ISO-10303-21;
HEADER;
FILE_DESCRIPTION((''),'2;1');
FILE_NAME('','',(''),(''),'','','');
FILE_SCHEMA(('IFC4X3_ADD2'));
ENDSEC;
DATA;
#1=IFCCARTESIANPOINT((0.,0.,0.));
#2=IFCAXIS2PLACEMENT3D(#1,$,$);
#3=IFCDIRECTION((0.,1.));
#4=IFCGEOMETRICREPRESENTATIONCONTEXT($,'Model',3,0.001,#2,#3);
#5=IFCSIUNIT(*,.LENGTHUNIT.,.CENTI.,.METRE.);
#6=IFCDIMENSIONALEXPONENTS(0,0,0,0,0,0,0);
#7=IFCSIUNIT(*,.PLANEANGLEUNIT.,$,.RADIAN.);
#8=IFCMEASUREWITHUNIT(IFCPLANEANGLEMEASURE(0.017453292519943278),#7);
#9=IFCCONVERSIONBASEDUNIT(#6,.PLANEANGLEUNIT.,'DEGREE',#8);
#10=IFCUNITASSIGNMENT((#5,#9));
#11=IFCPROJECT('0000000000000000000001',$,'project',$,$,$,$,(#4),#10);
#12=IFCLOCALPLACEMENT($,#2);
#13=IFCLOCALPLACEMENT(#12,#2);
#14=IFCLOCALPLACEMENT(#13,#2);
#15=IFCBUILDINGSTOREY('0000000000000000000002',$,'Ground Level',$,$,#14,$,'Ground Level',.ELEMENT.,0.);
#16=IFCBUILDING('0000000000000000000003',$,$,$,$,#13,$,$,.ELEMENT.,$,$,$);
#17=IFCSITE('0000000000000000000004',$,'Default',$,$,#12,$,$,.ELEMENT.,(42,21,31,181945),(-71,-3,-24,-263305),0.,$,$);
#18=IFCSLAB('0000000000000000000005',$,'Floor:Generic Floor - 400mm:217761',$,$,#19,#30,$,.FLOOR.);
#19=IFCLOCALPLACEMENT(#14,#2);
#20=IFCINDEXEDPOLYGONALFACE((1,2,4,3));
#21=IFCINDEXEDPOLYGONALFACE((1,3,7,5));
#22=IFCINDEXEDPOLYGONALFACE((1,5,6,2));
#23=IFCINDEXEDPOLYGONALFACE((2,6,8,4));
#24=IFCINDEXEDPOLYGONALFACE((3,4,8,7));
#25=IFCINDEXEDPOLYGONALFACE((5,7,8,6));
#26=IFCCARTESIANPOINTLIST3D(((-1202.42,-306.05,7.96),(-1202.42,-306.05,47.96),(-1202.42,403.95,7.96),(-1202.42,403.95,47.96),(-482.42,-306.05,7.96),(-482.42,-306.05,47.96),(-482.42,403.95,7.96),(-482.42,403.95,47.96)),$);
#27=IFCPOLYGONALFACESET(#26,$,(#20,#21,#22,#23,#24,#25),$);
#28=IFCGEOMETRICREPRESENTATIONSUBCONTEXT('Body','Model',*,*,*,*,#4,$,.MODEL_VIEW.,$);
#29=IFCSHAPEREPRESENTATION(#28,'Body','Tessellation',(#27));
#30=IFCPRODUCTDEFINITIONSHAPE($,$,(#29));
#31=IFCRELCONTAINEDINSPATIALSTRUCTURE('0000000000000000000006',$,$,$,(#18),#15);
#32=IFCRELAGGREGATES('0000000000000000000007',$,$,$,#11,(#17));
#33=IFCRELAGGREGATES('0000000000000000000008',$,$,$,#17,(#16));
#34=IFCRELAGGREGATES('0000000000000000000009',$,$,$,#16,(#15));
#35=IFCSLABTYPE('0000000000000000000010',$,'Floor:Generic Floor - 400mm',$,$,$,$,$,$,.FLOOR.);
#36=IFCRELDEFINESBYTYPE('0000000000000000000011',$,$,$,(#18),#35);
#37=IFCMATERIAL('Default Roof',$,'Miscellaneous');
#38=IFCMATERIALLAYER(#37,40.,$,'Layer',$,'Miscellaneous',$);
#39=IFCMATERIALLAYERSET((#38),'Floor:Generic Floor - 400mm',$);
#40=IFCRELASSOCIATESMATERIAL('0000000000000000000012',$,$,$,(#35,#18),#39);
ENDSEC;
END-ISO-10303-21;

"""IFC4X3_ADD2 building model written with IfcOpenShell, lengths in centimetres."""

from ifc_helpers import new_model, entity, si_unit, converted_unit, direction, frame, origin, origin_2d_with_axis, place, context, subcontext, project, spatial, rectangle, extrude, material, layer, layer_set, layer_usage, type_object, element, save


model = new_model("IFC4X3_ADD2")

# Units and contexts
model_context = context("Model", 3, precision=0.001, world=origin(), true_north=direction((0.0, 1.0)))
body_context = subcontext(model_context, "Body", "Model", "MODEL_VIEW")
ifc_project = project(units=[si_unit("LENGTHUNIT", "METRE", prefix="CENTI"), converted_unit("PLANEANGLEUNIT", "DEGREE", entity("IfcPlaneAngleMeasure", 0.017453292519943278), si_unit("PLANEANGLEUNIT", "RADIAN"), dimensions=[0, 0, 0, 0, 0, 0, 0])], contexts=[model_context])

# Site, building, storey
site_placement = place(None, origin())
site = spatial("IfcSite", under=ifc_project, at=site_placement, Name="Default", CompositionType="ELEMENT", RefLatitude=(42, 21, 31, 181945), RefLongitude=(-71, -3, -24, -263305), RefElevation=0.0)
building_placement = place(site_placement, origin())
building = spatial("IfcBuilding", under=site, at=building_placement, CompositionType="ELEMENT")
storey_placement = place(building_placement, origin())
storey = spatial("IfcBuildingStorey", under=building, at=storey_placement, Name="Ground Level", LongName="Ground Level", CompositionType="ELEMENT", Elevation=0.0)

# Slab
ifc_material = material(Name="Default Roof", Category="Miscellaneous")
ifc_layer = layer(ifc_material, 40.0, Name="Layer", Category="Miscellaneous")
ifc_layer_set = layer_set([ifc_layer], Name="Floor:Generic Floor - 400mm")
ifc_layer_usage = layer_usage(ifc_layer_set, "AXIS3", "POSITIVE", 0.0)
slab_type = type_object("IfcSlabType", Name="Floor:Generic Floor - 400mm", PredefinedType="FLOOR", material=ifc_layer_set)
slab_placement = place(storey_placement, origin())
element("IfcSlab", 1, at=slab_placement, inside=storey, type_object=slab_type, material=ifc_layer_usage, Name="Floor:Generic Floor - 400mm:217761", PredefinedType="FLOOR", context=body_context, shape_type="SweptSolid", body=[
    extrude(rectangle(XDim=710.0, YDim=720.0, at=origin_2d_with_axis()), frame((-842.42, 48.95, 47.96), z_axis=(0.0, 0.0, -1.0), x_axis=(0.0, 1.0, 0.0)), (0.0, 0.0, 1.0), 40.0),
])

save(model, "model.ifc")
